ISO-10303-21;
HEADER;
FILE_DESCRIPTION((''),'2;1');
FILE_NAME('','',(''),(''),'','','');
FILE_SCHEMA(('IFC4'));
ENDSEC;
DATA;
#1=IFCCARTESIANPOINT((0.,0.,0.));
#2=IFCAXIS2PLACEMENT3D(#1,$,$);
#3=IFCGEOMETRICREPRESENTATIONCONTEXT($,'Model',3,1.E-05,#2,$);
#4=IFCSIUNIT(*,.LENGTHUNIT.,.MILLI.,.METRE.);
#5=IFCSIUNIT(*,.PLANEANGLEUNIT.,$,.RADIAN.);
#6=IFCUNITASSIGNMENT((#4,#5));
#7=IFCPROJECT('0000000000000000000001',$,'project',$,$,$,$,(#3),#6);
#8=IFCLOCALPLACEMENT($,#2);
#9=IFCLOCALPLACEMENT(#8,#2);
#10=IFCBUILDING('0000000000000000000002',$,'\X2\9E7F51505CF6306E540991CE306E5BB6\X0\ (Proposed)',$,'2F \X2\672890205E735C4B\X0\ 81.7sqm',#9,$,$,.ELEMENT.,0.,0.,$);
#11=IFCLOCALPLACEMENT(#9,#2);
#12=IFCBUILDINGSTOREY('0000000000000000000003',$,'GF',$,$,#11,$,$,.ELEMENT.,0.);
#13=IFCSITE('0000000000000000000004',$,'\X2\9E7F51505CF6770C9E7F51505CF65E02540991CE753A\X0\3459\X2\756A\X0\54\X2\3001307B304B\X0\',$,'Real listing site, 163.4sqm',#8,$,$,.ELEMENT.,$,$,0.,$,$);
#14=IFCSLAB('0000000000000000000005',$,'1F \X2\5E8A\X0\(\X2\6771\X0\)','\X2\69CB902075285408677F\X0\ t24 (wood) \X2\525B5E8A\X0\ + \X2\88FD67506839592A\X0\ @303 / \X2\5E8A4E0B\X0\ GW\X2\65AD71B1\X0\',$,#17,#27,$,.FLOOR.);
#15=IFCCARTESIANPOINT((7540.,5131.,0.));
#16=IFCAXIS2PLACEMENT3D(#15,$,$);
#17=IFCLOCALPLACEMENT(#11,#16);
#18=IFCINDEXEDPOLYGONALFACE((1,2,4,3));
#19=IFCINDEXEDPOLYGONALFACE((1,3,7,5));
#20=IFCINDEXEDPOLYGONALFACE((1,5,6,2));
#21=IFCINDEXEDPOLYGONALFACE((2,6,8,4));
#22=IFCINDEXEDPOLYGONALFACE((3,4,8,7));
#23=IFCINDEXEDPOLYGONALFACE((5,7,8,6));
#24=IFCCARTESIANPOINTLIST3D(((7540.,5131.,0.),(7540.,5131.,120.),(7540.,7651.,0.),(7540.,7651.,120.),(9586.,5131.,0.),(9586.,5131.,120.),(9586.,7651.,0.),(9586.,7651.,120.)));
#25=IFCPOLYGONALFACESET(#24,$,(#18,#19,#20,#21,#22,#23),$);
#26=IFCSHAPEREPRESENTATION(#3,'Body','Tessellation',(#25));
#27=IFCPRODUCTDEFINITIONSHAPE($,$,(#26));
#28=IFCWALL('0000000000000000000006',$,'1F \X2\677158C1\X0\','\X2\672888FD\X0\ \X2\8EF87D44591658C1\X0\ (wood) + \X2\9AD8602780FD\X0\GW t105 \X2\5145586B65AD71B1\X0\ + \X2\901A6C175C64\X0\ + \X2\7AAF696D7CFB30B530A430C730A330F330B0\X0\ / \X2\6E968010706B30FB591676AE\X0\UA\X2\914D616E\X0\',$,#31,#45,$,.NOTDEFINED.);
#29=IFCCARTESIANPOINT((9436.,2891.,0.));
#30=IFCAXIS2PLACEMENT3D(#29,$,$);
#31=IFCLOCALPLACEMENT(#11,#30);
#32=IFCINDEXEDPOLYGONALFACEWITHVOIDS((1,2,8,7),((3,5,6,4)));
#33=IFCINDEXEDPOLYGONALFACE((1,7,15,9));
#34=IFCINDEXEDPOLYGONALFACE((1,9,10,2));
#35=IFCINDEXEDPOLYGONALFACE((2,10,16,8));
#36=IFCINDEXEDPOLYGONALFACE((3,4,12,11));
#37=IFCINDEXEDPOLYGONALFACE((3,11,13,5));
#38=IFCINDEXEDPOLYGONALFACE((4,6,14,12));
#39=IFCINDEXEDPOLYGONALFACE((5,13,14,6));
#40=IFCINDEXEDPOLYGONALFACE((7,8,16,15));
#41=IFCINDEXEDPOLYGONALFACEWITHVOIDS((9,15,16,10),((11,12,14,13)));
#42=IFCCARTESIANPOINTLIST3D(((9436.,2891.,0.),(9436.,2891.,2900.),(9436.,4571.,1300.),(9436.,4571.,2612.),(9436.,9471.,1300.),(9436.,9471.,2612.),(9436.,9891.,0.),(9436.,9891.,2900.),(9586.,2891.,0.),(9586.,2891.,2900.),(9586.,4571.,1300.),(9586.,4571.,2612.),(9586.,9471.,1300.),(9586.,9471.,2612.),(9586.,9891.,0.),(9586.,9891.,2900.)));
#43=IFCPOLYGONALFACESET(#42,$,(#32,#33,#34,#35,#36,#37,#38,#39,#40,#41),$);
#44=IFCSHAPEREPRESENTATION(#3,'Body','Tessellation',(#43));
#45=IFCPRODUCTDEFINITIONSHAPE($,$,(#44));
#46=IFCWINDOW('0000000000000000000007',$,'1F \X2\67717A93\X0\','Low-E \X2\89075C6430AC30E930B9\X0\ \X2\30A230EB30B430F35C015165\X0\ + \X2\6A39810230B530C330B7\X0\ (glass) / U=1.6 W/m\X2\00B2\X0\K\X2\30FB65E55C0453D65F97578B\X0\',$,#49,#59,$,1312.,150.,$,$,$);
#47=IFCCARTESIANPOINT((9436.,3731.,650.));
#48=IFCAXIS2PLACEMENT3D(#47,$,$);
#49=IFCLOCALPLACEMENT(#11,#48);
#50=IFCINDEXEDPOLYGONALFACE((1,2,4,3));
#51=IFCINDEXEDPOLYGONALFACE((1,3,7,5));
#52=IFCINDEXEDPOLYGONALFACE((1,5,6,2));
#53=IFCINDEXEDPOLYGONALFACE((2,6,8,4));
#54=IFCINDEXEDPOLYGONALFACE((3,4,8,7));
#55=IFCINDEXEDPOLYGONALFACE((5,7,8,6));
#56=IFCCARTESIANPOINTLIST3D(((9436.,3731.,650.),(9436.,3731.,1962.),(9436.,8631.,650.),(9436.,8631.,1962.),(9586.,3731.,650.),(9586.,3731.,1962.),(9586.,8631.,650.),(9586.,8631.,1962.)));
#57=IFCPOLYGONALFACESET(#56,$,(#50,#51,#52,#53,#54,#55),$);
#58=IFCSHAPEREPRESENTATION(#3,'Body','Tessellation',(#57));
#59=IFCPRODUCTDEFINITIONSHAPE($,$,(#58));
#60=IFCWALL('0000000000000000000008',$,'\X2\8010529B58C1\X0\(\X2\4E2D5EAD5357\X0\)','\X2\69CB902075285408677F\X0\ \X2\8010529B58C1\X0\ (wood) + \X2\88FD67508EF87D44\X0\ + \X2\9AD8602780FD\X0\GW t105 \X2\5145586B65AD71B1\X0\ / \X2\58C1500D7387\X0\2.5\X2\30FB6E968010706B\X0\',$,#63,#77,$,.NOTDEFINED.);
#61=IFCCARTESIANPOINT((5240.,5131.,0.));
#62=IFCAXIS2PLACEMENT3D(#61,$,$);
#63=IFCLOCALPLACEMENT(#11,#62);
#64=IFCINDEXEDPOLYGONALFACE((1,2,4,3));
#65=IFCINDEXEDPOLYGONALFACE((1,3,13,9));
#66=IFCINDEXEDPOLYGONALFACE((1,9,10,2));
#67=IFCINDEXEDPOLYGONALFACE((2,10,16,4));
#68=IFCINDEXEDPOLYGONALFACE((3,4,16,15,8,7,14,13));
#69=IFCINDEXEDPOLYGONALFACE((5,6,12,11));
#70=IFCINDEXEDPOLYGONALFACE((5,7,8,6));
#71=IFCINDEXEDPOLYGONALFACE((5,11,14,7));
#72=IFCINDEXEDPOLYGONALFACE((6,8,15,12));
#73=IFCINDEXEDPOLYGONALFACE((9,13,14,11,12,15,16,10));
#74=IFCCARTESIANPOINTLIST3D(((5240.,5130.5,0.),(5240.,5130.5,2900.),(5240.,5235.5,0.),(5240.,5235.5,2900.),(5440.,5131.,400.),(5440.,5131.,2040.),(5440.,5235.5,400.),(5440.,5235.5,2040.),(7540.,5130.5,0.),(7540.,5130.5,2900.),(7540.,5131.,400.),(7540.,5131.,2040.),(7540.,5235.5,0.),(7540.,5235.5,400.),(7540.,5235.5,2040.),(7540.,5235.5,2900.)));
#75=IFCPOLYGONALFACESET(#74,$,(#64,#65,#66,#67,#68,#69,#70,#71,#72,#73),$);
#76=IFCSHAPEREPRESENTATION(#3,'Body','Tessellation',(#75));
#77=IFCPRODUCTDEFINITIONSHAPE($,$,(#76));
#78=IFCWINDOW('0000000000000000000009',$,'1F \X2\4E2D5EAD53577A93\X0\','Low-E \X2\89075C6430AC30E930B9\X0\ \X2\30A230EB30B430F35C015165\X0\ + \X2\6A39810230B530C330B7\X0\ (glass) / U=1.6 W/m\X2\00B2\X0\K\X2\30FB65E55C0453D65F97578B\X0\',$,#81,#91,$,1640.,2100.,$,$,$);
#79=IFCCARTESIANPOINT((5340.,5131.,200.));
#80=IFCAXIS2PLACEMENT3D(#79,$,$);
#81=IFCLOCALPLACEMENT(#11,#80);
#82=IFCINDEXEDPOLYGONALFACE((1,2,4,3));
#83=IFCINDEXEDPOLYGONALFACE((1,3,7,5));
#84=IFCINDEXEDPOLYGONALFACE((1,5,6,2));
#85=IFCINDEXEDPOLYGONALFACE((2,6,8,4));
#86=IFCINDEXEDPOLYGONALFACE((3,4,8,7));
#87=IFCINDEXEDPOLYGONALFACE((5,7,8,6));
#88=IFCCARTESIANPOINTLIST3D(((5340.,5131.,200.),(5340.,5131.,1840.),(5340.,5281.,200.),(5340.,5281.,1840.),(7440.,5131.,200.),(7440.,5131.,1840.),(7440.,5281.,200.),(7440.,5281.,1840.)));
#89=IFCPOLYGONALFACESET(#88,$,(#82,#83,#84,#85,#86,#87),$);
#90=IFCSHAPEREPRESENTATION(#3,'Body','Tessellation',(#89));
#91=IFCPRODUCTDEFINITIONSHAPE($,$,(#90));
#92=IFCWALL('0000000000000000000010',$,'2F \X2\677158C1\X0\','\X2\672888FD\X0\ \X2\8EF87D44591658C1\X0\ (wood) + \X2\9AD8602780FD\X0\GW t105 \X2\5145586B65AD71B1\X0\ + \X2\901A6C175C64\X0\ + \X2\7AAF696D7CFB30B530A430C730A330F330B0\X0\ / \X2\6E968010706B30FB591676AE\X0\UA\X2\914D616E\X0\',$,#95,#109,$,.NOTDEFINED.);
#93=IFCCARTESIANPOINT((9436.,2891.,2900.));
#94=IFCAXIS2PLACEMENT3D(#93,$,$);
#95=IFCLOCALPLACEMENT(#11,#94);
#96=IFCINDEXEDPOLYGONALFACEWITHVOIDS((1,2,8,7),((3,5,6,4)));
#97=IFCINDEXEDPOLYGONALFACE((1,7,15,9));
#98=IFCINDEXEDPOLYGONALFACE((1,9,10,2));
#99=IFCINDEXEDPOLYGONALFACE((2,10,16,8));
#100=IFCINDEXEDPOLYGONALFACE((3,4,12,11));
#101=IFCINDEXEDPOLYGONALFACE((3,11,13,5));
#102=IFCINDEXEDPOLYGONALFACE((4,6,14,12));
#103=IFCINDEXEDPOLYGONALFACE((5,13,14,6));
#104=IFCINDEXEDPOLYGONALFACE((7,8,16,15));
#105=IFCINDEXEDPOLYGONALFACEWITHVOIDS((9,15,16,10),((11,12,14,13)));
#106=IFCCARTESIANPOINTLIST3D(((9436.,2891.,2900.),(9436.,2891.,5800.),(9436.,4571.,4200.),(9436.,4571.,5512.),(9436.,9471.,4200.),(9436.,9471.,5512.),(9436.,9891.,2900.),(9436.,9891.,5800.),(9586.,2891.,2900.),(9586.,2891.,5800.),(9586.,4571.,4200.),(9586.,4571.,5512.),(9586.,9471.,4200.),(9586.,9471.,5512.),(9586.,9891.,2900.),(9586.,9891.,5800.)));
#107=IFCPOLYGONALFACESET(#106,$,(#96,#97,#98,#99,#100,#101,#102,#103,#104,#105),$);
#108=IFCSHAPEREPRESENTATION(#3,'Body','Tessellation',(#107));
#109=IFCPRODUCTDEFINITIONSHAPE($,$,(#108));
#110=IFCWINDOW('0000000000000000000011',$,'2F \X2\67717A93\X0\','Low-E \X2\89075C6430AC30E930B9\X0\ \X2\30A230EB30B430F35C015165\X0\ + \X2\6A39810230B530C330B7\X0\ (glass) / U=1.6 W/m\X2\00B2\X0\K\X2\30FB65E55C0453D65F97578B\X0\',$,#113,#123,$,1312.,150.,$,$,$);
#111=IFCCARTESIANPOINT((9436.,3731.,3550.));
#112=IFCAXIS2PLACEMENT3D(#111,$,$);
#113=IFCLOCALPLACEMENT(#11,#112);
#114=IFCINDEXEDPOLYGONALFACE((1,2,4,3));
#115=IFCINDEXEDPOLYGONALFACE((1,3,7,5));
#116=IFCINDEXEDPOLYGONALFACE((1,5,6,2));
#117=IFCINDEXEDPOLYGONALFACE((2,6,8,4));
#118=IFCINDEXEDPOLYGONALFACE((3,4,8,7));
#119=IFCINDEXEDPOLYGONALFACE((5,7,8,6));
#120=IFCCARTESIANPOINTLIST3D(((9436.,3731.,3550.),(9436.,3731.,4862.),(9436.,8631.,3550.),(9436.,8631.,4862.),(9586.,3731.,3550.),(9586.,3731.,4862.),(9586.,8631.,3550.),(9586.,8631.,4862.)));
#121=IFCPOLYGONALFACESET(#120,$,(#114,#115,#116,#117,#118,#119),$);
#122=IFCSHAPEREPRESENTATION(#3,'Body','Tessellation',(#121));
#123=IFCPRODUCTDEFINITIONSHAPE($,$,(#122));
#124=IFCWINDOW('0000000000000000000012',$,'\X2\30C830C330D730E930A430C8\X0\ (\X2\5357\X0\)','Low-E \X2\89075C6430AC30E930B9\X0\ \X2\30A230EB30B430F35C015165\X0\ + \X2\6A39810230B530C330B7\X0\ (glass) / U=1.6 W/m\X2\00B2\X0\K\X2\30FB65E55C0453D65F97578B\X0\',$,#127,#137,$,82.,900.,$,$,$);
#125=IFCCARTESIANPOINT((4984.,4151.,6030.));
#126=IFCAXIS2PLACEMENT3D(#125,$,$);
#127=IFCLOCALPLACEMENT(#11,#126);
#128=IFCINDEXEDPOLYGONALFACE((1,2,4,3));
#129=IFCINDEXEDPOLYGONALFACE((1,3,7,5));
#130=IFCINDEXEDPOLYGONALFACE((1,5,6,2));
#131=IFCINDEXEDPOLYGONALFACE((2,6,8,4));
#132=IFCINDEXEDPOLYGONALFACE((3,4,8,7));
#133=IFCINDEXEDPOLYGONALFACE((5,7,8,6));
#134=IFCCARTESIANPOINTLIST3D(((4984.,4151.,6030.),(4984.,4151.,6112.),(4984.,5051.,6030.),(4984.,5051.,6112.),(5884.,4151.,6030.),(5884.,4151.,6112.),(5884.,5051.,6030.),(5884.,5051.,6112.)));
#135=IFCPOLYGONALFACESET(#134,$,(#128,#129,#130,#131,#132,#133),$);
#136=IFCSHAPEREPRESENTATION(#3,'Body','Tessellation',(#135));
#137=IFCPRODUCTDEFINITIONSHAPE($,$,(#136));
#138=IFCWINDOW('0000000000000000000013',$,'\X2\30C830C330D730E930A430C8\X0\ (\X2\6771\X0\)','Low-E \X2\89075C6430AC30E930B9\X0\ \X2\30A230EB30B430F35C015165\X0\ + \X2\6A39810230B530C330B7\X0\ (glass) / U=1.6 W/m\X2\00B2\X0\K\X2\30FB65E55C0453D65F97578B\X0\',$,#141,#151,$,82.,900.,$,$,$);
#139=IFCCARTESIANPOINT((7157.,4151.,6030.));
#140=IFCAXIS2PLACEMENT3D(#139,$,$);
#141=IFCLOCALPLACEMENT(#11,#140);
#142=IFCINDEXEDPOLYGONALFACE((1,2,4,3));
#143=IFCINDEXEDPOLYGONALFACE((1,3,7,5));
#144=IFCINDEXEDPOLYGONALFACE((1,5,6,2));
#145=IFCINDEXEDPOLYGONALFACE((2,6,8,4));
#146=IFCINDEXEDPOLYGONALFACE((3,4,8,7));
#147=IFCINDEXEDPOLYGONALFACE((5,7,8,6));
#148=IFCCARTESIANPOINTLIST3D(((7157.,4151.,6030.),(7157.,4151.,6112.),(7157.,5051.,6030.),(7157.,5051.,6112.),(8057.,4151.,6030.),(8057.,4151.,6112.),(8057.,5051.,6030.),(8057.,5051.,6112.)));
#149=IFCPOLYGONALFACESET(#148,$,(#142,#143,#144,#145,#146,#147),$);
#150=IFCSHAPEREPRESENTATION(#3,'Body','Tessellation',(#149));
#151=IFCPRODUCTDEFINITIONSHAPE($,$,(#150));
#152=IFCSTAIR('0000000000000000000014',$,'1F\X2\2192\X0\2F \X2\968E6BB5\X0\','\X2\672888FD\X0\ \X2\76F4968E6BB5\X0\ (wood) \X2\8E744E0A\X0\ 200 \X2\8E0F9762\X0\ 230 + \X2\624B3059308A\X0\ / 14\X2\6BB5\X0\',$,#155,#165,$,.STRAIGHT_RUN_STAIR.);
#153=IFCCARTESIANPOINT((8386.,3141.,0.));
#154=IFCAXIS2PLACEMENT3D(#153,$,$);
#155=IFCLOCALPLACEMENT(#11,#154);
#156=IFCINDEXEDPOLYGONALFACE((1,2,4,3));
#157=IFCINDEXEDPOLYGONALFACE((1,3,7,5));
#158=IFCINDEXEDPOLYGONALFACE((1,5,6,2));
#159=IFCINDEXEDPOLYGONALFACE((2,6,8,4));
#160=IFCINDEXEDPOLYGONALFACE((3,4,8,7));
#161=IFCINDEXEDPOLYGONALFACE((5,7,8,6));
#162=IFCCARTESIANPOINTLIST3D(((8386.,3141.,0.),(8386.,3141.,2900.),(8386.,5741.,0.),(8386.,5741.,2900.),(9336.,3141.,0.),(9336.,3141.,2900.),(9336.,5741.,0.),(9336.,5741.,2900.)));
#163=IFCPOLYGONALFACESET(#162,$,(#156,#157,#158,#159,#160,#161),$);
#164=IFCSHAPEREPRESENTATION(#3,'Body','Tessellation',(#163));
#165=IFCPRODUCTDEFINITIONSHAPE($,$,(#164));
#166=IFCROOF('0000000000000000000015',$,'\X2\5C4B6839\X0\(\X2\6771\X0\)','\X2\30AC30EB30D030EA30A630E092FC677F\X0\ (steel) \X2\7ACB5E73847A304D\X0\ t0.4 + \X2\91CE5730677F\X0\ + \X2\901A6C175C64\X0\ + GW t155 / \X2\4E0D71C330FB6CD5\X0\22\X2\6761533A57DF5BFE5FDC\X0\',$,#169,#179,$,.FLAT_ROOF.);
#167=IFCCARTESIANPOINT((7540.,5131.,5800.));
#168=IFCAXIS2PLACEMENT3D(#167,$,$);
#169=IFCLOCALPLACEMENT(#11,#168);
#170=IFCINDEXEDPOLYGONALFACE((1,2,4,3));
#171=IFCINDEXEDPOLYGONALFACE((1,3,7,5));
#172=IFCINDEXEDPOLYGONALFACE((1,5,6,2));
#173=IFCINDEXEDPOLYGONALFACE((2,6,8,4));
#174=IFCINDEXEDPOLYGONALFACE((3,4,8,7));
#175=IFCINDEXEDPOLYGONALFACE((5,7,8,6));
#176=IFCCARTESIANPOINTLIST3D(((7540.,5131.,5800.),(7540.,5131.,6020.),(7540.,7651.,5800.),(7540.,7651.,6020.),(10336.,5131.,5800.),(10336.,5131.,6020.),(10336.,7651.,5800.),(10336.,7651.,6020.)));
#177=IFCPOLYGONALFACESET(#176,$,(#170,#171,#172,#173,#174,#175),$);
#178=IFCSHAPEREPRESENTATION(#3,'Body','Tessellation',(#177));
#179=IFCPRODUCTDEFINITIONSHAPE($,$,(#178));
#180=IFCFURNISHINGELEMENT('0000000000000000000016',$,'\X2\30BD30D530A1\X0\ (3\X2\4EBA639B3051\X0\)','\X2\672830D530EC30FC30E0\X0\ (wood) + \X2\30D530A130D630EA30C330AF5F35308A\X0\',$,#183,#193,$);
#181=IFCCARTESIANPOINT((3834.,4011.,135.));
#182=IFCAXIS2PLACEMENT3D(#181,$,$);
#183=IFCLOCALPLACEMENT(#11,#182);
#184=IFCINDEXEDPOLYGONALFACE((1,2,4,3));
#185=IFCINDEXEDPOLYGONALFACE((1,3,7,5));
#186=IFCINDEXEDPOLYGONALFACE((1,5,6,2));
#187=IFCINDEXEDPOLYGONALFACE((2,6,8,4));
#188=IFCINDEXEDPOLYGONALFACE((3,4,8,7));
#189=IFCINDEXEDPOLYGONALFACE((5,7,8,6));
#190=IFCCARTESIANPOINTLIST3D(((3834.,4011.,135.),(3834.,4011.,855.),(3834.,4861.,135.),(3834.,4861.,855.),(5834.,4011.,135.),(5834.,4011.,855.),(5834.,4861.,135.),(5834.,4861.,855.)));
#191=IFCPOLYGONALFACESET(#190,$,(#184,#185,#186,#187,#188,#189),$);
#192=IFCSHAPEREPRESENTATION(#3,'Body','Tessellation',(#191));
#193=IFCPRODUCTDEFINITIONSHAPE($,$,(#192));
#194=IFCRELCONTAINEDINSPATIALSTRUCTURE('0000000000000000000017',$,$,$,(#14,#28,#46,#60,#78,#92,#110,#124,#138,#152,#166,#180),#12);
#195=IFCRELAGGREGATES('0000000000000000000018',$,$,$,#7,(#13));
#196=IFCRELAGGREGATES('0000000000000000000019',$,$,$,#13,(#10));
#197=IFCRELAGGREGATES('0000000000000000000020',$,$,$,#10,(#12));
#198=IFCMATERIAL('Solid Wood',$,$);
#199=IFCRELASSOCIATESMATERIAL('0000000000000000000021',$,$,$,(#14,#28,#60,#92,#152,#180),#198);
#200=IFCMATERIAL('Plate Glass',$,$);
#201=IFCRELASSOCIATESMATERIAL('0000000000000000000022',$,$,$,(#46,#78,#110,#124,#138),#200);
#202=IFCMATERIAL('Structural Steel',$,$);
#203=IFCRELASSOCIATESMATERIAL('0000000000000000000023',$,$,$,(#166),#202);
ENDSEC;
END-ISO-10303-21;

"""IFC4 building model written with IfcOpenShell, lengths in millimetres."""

from ifc_helpers import new_model, si_unit, frame, frame_2d, origin, place, context, project, spatial, rectangle, extrude, material, element, fill, save


model = new_model("IFC4")

# Units and contexts
model_context = context("Model", 3, precision=1e-05, world=origin())
ifc_project = project(units=[si_unit("LENGTHUNIT", "METRE", prefix="MILLI"), si_unit("PLANEANGLEUNIT", "RADIAN")], contexts=[model_context])

# Site, building, storey
site_placement = place(None, origin())
site = spatial("IfcSite", under=ifc_project, at=site_placement, Name="鹿児島県鹿児島市吉野町3459番54、ほか", ObjectType="Real listing site, 163.4sqm", CompositionType="ELEMENT", RefElevation=0.0)
building_placement = place(site_placement, origin())
building = spatial("IfcBuilding", under=site, at=building_placement, Name="鹿児島の吉野の家 (Proposed)", ObjectType="2F 木造平屋 81.7sqm", CompositionType="ELEMENT", ElevationOfRefHeight=0.0, ElevationOfTerrain=0.0)
storey_placement = place(building_placement, origin())
storey = spatial("IfcBuildingStorey", under=building, at=storey_placement, Name="GF", CompositionType="ELEMENT", Elevation=0.0)

# Slab
ifc_material_1 = material(Name="Solid Wood")
slab_placement = place(storey_placement, frame((7540.0, 5131.0, 0.0)))
element("IfcSlab", 1, at=slab_placement, inside=storey, material=ifc_material_1, Name="1F 床(東)", Description="構造用合板 t24 (wood) 剛床 + 製材根太 @303 / 床下 GW断熱", PredefinedType="FLOOR", context=model_context, shape_type="SweptSolid", body=[
    extrude(rectangle(XDim=2046.0, YDim=2520.0, at=frame_2d((1023.0, 1260.0))), frame((7540.0, 5131.0, 0.0)), (0.0, 0.0, 1.0), 120.0),
])

# Walls, openings, windows
wall_1_placement = place(storey_placement, frame((9436.0, 2891.0, 0.0)))
wall_1 = element("IfcWall", 2, at=wall_1_placement, inside=storey, material=ifc_material_1, Name="1F 東壁", Description="木製 軸組外壁 (wood) + 高性能GW t105 充填断熱 + 通気層 + 窯業系サイディング / 準耐火・外皮UA配慮", PredefinedType="NOTDEFINED", context=model_context, shape_type="SweptSolid", body=[
    extrude(rectangle(XDim=150.0, YDim=7000.0, at=frame_2d((75.0, 3500.0))), frame((9436.0, 2891.0, 0.0)), (0.0, 0.0, 1.0), 2900.0),
])
opening_1_placement = place(storey_placement, frame((9436.0, 3731.0, 650.0)))
opening_1 = element("IfcOpeningElement", 3, at=opening_1_placement, cuts=wall_1, PredefinedType="NOTDEFINED", context=model_context, shape_type="SweptSolid", body=[
    extrude(rectangle(XDim=150.0, YDim=4900.0, at=frame_2d((75.0, 2450.0))), frame((9436.0, 3731.0, 650.0)), (0.0, 0.0, 1.0), 1312.0),
])
ifc_material_2 = material(Name="Plate Glass")
window_1_placement = place(storey_placement, frame((9436.0, 3731.0, 650.0)))
window_1 = element("IfcWindow", 4, at=window_1_placement, inside=storey, material=ifc_material_2, Name="1F 東窓", Description="Low-E 複層ガラス アルゴン封入 + 樹脂サッシ (glass) / U=1.6 W/m²K・日射取得型", OverallHeight=1312.0, OverallWidth=150.0, context=model_context, shape_type="SweptSolid", body=[
    extrude(rectangle(XDim=150.0, YDim=4900.0, at=frame_2d((75.0, 2450.0))), frame((9436.0, 3731.0, 650.0)), (0.0, 0.0, 1.0), 1312.0),
])
fill(opening_1, window_1)
wall_2_placement = place(storey_placement, frame((5240.0, 5131.0, 0.0)))
wall_2 = element("IfcWall", 5, at=wall_2_placement, inside=storey, material=ifc_material_1, Name="耐力壁(中庭南)", Description="構造用合板 耐力壁 (wood) + 製材軸組 + 高性能GW t105 充填断熱 / 壁倍率2.5・準耐火", PredefinedType="NOTDEFINED", context=model_context, shape_type="SweptSolid", body=[
    extrude(rectangle(XDim=2300.0, YDim=105.0, at=frame_2d((1150.0, 52.0))), frame((5240.0, 5131.0, 0.0)), (0.0, 0.0, 1.0), 2900.0),
])
opening_2_placement = place(storey_placement, frame((5340.0, 5131.0, 200.0)))
opening_2 = element("IfcOpeningElement", 6, at=opening_2_placement, cuts=wall_2, PredefinedType="NOTDEFINED", context=model_context, shape_type="SweptSolid", body=[
    extrude(rectangle(XDim=2100.0, YDim=150.0, at=frame_2d((1050.0, 75.0))), frame((5340.0, 5131.0, 200.0)), (0.0, 0.0, 1.0), 1640.0),
])
window_2_placement = place(storey_placement, frame((5340.0, 5131.0, 200.0)))
window_2 = element("IfcWindow", 7, at=window_2_placement, inside=storey, material=ifc_material_2, Name="1F 中庭南窓", Description="Low-E 複層ガラス アルゴン封入 + 樹脂サッシ (glass) / U=1.6 W/m²K・日射取得型", OverallHeight=1640.0, OverallWidth=2100.0, context=model_context, shape_type="SweptSolid", body=[
    extrude(rectangle(XDim=2100.0, YDim=150.0, at=frame_2d((1050.0, 75.0))), frame((5340.0, 5131.0, 200.0)), (0.0, 0.0, 1.0), 1640.0),
])
fill(opening_2, window_2)

# Wall, opening, window
wall_3_placement = place(storey_placement, frame((9436.0, 2891.0, 2900.0)))
wall_3 = element("IfcWall", 8, at=wall_3_placement, inside=storey, material=ifc_material_1, Name="2F 東壁", Description="木製 軸組外壁 (wood) + 高性能GW t105 充填断熱 + 通気層 + 窯業系サイディング / 準耐火・外皮UA配慮", PredefinedType="NOTDEFINED", context=model_context, shape_type="SweptSolid", body=[
    extrude(rectangle(XDim=150.0, YDim=7000.0, at=frame_2d((75.0, 3500.0))), frame((9436.0, 2891.0, 2900.0)), (0.0, 0.0, 1.0), 2900.0),
])
opening_3_placement = place(storey_placement, frame((9436.0, 3731.0, 3550.0)))
opening_3 = element("IfcOpeningElement", 9, at=opening_3_placement, cuts=wall_3, PredefinedType="NOTDEFINED", context=model_context, shape_type="SweptSolid", body=[
    extrude(rectangle(XDim=150.0, YDim=4900.0, at=frame_2d((75.0, 2450.0))), frame((9436.0, 3731.0, 3550.0)), (0.0, 0.0, 1.0), 1312.0),
])
window_3_placement = place(storey_placement, frame((9436.0, 3731.0, 3550.0)))
window_3 = element("IfcWindow", 10, at=window_3_placement, inside=storey, material=ifc_material_2, Name="2F 東窓", Description="Low-E 複層ガラス アルゴン封入 + 樹脂サッシ (glass) / U=1.6 W/m²K・日射取得型", OverallHeight=1312.0, OverallWidth=150.0, context=model_context, shape_type="SweptSolid", body=[
    extrude(rectangle(XDim=150.0, YDim=4900.0, at=frame_2d((75.0, 2450.0))), frame((9436.0, 3731.0, 3550.0)), (0.0, 0.0, 1.0), 1312.0),
])
fill(opening_3, window_3)

# Windows
window_4_placement = place(storey_placement, frame((4984.0, 4151.0, 6030.0)))
element("IfcWindow", 11, at=window_4_placement, inside=storey, material=ifc_material_2, Name="トップライト (南)", Description="Low-E 複層ガラス アルゴン封入 + 樹脂サッシ (glass) / U=1.6 W/m²K・日射取得型", OverallHeight=82.0, OverallWidth=900.0, context=model_context, shape_type="SweptSolid", body=[
    extrude(rectangle(XDim=900.0, YDim=900.0, at=frame_2d((450.0, 450.0))), frame((4984.0, 4151.0, 6030.0)), (0.0, 0.0, 1.0), 82.0),
])
window_5_placement = place(storey_placement, frame((7157.0, 4151.0, 6030.0)))
element("IfcWindow", 12, at=window_5_placement, inside=storey, material=ifc_material_2, Name="トップライト (東)", Description="Low-E 複層ガラス アルゴン封入 + 樹脂サッシ (glass) / U=1.6 W/m²K・日射取得型", OverallHeight=82.0, OverallWidth=900.0, context=model_context, shape_type="SweptSolid", body=[
    extrude(rectangle(XDim=900.0, YDim=900.0, at=frame_2d((450.0, 450.0))), frame((7157.0, 4151.0, 6030.0)), (0.0, 0.0, 1.0), 82.0),
])

# Stair
stair_placement = place(storey_placement, frame((8386.0, 3141.0, 0.0)))
element("IfcStair", 13, at=stair_placement, inside=storey, material=ifc_material_1, Name="1F→2F 階段", Description="木製 直階段 (wood) 蹴上 200 踏面 230 + 手すり / 14段", PredefinedType="STRAIGHT_RUN_STAIR", context=model_context, shape_type="SweptSolid", body=[
    extrude(rectangle(XDim=950.0, YDim=2600.0, at=frame_2d((475.0, 1300.0))), frame((8386.0, 3141.0, 0.0)), (0.0, 0.0, 1.0), 2900.0),
])

# Roof
ifc_material_3 = material(Name="Structural Steel")
roof_placement = place(storey_placement, frame((7540.0, 5131.0, 5800.0)))
element("IfcRoof", 14, at=roof_placement, inside=storey, material=ifc_material_3, Name="屋根(東)", Description="ガルバリウム鋼板 (steel) 立平葺き t0.4 + 野地板 + 通気層 + GW t155 / 不燃・法22条区域対応", PredefinedType="FLAT_ROOF", context=model_context, shape_type="SweptSolid", body=[
    extrude(rectangle(XDim=2796.0, YDim=2520.0, at=frame_2d((1398.0, 1260.0))), frame((7540.0, 5131.0, 5800.0)), (0.0, 0.0, 1.0), 220.0),
])

# Furnishing element
furnishing_1_placement = place(storey_placement, frame((3834.0, 4011.0, 135.0)))
element("IfcFurnishingElement", 15, at=furnishing_1_placement, inside=storey, material=ifc_material_1, Name="ソファ (3人掛け)", Description="木フレーム (wood) + ファブリック張り", context=model_context, shape_type="SweptSolid", body=[
    extrude(rectangle(XDim=2000.0, YDim=850.0, at=frame_2d((1000.0, 425.0))), frame((3834.0, 4011.0, 135.0)), (0.0, 0.0, 1.0), 720.0),
])

save(model, "model.ifc")
